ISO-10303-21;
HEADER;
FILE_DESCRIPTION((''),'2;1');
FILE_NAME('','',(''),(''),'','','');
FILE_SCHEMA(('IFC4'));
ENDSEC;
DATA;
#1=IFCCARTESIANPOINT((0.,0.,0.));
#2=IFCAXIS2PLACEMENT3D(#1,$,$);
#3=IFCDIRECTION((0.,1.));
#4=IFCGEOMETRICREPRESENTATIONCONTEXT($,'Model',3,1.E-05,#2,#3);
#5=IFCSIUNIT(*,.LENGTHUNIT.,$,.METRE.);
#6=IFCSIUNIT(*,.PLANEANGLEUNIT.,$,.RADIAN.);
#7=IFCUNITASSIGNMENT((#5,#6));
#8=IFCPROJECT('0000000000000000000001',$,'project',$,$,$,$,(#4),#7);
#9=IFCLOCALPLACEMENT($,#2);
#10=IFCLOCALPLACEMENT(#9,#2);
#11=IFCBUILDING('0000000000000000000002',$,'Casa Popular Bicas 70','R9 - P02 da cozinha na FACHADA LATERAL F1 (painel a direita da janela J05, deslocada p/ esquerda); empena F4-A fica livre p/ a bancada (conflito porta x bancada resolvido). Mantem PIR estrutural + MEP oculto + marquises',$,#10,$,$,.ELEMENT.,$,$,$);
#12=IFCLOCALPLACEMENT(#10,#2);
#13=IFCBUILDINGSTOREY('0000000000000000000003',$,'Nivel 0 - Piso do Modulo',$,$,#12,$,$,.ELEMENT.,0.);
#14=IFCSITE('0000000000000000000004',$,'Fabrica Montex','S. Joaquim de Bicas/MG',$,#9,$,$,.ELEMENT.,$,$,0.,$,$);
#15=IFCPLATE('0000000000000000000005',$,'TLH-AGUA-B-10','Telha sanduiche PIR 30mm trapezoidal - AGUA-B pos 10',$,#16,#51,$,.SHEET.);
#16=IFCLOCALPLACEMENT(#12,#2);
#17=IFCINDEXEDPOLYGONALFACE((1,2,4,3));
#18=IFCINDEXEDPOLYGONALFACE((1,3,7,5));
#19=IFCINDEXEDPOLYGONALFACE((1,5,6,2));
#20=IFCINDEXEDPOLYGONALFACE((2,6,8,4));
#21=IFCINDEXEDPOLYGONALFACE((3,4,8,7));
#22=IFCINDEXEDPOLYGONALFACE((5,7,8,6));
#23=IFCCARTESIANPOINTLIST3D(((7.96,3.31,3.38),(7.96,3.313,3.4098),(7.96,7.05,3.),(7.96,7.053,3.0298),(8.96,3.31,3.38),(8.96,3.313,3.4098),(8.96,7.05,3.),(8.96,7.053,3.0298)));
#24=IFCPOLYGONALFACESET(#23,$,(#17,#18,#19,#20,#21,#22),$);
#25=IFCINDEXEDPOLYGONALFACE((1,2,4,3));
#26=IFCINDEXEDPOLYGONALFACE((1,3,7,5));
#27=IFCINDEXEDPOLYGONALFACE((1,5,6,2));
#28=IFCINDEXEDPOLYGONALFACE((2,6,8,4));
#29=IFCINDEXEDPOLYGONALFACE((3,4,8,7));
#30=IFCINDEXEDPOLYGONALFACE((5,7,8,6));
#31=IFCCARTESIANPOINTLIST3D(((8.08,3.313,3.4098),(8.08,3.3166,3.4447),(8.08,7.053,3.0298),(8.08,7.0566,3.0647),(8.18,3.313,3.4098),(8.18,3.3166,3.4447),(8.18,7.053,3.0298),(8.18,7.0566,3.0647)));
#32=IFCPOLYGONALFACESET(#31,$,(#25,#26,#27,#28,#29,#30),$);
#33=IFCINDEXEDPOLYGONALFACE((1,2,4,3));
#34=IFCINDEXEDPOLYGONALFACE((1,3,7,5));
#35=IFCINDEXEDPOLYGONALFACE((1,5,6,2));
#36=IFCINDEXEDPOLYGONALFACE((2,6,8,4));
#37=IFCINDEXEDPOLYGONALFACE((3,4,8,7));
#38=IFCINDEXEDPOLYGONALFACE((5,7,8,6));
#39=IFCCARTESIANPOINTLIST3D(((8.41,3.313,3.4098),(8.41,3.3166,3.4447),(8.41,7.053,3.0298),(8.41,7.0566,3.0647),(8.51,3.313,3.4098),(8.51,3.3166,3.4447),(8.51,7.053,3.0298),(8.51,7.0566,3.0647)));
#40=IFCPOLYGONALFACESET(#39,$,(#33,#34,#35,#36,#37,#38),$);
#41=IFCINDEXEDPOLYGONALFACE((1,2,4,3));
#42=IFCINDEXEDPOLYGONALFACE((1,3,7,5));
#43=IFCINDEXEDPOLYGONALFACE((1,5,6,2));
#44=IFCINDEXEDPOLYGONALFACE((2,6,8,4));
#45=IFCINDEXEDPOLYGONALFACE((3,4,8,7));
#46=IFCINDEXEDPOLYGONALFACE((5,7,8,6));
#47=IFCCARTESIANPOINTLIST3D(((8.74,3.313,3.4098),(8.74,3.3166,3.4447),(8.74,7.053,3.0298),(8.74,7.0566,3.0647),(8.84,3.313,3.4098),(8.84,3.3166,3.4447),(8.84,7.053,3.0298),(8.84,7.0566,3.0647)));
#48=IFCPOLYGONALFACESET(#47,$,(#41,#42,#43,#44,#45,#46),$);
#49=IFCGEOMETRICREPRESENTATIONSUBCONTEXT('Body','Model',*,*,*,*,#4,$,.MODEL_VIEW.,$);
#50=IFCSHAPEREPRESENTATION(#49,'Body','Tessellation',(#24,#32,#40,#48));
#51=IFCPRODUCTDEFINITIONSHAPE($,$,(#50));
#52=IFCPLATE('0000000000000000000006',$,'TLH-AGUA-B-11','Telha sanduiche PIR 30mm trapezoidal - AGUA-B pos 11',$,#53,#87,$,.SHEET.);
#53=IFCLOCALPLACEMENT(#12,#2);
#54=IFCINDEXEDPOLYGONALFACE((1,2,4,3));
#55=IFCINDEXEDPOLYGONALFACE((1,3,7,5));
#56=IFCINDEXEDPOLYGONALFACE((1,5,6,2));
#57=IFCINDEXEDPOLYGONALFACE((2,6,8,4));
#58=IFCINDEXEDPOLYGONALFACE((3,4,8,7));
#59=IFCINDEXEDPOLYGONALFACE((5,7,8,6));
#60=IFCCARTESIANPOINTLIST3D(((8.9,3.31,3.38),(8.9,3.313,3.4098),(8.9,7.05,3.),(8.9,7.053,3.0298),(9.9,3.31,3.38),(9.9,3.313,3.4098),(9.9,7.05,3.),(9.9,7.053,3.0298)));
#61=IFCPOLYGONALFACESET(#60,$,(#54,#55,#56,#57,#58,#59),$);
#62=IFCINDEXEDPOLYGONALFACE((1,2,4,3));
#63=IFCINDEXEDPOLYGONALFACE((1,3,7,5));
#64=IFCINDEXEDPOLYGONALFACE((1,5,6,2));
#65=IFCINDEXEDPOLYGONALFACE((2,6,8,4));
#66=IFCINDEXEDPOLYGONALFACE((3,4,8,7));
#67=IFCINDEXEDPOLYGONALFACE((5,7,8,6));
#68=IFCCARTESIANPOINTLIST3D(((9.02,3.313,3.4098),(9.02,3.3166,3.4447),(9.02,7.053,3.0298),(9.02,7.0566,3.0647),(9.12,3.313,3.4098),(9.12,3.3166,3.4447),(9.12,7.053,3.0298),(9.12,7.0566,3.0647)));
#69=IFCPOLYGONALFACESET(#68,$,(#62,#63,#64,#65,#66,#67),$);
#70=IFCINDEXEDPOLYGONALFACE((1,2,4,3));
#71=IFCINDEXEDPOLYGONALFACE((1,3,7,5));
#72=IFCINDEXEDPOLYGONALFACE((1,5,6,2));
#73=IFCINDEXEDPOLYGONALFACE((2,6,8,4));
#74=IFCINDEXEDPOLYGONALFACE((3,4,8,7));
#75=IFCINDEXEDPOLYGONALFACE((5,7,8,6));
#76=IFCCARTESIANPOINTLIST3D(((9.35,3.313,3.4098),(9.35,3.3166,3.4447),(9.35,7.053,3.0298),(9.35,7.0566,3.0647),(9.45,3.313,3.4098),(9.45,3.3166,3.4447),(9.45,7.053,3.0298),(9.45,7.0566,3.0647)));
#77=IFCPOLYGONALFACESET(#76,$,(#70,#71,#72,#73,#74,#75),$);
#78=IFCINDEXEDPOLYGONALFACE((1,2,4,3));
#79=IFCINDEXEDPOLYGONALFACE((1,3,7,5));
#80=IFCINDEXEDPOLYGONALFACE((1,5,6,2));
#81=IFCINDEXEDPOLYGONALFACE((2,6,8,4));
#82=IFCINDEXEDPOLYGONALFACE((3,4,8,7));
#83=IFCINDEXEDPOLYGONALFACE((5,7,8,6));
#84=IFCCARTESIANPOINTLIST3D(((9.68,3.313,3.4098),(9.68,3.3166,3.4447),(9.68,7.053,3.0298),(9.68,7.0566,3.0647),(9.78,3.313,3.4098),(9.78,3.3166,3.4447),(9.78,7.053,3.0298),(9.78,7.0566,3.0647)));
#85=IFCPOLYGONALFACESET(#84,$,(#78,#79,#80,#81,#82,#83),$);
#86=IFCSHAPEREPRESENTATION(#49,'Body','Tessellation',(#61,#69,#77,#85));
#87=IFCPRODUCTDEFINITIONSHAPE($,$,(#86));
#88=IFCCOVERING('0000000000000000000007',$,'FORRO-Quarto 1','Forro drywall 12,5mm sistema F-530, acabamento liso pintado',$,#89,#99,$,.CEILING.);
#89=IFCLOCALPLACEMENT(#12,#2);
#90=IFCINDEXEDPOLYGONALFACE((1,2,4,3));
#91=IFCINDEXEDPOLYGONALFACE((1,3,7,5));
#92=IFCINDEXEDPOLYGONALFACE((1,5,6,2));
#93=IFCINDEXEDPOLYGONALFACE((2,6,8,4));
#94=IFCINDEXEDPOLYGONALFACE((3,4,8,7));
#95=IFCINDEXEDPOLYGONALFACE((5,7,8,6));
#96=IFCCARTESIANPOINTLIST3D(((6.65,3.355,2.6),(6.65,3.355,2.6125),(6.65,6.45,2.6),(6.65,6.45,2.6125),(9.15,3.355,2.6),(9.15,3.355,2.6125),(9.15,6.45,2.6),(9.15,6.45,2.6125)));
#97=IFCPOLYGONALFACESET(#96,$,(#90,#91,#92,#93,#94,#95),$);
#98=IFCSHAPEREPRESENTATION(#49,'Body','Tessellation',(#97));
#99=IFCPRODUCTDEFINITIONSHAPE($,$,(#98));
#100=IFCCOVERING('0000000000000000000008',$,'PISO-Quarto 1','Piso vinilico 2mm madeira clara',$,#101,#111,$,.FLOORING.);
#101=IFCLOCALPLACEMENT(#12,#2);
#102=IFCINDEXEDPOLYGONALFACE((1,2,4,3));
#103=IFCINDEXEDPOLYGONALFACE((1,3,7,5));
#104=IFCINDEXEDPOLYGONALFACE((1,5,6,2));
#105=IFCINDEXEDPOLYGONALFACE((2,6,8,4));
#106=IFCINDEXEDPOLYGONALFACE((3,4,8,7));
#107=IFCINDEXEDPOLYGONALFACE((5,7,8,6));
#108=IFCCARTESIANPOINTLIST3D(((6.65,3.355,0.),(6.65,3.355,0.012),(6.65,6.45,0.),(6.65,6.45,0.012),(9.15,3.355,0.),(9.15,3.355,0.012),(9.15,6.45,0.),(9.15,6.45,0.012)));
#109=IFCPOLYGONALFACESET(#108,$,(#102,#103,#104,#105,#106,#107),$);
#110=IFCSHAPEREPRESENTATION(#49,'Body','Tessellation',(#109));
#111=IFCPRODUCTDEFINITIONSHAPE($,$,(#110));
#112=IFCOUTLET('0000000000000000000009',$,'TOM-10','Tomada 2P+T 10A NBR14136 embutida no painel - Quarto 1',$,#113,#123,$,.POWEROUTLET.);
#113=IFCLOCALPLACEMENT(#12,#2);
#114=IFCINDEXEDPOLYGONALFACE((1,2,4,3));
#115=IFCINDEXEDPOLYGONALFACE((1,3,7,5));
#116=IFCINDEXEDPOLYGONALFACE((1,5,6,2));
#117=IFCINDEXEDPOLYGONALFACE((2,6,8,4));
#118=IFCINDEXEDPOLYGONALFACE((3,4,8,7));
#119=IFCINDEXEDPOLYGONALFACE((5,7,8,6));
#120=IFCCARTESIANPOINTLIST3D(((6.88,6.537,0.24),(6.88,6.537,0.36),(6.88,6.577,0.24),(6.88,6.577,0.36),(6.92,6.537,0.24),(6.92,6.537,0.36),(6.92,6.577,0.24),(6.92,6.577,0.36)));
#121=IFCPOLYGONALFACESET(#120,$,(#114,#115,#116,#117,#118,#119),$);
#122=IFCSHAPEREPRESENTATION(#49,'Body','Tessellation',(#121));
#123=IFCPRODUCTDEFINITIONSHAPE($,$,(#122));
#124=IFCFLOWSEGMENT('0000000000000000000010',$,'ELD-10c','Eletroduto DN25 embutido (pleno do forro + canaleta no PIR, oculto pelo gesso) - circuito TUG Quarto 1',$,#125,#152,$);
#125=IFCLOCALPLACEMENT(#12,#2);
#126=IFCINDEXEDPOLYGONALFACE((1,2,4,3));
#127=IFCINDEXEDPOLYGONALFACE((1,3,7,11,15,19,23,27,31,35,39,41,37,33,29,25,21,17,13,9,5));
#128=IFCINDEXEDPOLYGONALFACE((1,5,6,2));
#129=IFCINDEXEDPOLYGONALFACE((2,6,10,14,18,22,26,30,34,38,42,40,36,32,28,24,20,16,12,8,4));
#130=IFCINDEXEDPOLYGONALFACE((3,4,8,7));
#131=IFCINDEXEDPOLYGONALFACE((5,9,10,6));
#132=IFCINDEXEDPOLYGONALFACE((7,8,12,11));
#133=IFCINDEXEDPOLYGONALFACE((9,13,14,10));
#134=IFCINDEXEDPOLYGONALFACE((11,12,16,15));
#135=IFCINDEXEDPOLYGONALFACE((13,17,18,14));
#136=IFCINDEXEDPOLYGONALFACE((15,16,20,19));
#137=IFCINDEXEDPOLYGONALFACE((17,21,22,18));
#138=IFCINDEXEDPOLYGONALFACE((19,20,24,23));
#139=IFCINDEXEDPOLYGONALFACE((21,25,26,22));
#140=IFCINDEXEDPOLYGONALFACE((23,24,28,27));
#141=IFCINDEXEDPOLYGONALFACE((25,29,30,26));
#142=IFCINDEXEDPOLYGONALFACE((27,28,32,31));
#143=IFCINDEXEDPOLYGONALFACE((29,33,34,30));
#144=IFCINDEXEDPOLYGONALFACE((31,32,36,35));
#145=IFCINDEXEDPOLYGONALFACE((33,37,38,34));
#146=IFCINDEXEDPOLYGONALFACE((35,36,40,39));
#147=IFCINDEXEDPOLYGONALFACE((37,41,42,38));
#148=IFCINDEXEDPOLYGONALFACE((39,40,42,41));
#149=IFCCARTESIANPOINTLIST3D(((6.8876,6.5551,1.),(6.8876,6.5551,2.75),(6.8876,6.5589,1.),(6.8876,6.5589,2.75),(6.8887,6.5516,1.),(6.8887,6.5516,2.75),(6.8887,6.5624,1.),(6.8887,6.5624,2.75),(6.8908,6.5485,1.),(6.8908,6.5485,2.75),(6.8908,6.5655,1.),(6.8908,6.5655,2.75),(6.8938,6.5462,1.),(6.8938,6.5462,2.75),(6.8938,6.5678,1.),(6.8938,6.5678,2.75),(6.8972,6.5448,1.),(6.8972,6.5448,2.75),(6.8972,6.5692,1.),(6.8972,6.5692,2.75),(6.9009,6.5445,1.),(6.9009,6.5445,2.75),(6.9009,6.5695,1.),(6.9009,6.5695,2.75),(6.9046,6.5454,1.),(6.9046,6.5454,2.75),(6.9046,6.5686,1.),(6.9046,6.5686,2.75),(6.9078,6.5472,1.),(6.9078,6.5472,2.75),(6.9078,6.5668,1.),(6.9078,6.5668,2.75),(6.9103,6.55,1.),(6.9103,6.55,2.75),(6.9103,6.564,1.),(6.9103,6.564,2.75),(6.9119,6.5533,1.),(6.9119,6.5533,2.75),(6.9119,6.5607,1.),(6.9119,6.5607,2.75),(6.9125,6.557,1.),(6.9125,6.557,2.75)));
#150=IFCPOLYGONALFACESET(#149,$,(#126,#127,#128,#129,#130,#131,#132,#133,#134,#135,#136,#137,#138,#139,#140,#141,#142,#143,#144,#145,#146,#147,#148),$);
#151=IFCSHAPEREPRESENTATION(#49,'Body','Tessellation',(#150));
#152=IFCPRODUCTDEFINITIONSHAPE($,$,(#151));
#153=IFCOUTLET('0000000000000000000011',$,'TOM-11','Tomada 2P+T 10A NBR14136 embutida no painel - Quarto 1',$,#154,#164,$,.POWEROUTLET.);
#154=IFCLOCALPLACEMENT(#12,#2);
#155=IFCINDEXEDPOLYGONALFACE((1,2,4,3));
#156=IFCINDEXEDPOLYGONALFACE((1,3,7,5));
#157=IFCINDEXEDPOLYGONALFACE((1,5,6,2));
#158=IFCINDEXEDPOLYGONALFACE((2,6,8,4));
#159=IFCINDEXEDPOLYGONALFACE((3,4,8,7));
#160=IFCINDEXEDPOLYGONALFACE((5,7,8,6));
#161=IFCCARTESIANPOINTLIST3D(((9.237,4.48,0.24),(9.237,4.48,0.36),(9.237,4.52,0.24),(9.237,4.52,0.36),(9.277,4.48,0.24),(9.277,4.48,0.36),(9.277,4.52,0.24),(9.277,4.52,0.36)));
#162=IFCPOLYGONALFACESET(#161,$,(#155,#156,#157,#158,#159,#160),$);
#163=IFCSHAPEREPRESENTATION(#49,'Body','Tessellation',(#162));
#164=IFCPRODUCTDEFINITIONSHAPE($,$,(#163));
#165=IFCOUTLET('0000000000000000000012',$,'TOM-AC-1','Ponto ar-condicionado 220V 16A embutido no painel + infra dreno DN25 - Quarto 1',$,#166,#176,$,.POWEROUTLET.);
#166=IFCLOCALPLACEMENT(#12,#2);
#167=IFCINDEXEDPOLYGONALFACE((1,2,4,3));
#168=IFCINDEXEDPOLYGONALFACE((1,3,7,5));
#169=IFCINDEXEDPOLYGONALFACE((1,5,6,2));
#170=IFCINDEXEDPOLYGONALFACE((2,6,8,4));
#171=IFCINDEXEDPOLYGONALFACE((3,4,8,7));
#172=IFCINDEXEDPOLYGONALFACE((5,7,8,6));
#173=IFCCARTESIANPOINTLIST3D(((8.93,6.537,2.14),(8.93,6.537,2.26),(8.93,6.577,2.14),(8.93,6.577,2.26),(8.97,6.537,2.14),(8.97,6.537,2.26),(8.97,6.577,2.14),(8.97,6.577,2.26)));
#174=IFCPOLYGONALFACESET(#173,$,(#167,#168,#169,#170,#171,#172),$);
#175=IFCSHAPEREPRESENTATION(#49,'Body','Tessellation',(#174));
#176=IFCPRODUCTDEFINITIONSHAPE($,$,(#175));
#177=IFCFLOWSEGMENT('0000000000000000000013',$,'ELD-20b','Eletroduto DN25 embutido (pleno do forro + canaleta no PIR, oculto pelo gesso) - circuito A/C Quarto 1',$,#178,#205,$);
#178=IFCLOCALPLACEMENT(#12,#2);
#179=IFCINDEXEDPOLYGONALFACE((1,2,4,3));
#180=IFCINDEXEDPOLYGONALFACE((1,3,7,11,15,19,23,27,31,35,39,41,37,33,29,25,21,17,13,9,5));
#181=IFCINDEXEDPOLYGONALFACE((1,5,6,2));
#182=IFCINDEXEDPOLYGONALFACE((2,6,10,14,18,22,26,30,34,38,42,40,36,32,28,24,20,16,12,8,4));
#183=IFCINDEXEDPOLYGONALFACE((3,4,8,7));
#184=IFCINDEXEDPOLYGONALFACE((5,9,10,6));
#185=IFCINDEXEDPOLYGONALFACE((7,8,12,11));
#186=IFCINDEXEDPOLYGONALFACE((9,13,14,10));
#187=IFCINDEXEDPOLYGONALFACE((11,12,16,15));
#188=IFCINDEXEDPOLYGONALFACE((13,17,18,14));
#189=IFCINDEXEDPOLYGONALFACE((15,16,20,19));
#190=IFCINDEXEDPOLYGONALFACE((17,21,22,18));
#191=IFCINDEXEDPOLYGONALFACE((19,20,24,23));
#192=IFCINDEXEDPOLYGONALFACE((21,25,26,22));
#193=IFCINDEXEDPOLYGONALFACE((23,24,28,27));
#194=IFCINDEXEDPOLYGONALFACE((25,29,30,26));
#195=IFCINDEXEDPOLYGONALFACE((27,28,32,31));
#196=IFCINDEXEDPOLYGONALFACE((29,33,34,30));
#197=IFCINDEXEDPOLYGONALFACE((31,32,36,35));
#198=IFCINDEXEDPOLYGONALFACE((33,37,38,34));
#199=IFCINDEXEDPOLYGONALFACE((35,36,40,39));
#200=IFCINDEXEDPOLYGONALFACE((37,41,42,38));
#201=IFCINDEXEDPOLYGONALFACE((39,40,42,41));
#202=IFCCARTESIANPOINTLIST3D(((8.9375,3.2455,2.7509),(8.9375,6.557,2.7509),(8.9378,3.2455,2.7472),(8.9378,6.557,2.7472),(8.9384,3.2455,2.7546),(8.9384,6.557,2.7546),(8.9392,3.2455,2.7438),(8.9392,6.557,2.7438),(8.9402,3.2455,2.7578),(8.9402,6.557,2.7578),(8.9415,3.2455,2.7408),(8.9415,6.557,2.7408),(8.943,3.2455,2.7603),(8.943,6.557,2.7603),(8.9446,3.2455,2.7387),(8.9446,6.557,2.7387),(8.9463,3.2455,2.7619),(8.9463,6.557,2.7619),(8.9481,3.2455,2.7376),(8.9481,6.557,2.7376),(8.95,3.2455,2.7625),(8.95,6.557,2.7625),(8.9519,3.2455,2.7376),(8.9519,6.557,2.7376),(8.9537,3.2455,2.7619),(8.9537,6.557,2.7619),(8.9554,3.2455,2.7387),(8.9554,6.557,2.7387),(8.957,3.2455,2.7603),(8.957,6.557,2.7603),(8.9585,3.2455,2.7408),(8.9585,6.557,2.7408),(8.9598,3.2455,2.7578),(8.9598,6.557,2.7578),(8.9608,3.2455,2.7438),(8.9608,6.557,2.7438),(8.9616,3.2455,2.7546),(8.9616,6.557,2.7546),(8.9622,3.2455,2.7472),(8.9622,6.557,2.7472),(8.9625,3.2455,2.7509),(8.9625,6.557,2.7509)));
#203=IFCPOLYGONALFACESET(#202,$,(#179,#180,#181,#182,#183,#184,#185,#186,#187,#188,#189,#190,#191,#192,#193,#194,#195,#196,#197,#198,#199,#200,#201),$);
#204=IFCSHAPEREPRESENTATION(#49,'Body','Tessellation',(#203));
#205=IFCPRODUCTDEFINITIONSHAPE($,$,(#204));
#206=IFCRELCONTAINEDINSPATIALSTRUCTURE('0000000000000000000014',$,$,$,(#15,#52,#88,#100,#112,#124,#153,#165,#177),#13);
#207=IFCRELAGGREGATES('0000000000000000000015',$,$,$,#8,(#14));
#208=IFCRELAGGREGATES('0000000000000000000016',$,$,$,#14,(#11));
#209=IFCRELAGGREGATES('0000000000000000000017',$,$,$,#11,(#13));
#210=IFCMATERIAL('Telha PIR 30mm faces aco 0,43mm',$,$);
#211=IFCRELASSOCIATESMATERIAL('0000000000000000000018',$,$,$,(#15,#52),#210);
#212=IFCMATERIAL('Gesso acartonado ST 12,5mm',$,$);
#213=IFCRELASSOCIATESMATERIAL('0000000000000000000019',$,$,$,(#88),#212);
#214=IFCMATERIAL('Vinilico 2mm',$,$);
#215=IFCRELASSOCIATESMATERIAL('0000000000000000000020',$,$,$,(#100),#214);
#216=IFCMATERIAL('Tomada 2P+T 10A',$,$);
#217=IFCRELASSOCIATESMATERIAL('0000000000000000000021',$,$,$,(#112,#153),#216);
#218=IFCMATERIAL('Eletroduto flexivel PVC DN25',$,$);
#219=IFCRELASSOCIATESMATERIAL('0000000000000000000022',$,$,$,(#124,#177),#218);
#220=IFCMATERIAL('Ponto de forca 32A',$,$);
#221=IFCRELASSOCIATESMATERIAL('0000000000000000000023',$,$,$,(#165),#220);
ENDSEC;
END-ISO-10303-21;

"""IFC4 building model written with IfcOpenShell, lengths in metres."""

from ifc_helpers import new_model, si_unit, direction, frame, frame_2d, origin, origin_2d, place, context, subcontext, project, spatial, rectangle, circle, extrude, material, element, save


model = new_model("IFC4")

# Units and contexts
model_context_1 = context("Model", 3, precision=1e-05, world=origin(), true_north=direction((0.0, 1.0)))
body_context_1 = subcontext(model_context_1, "Body", "Model", "MODEL_VIEW")
ifc_project = project(units=[si_unit("LENGTHUNIT", "METRE"), si_unit("PLANEANGLEUNIT", "RADIAN")], contexts=[model_context_1])

# Site, building, storey
site_placement = place(None, origin())
site = spatial("IfcSite", under=ifc_project, at=site_placement, Name="Fabrica Montex", Description="S. Joaquim de Bicas/MG", CompositionType="ELEMENT", RefElevation=0.0)
building_placement = place(site_placement, origin())
building = spatial("IfcBuilding", under=site, at=building_placement, Name="Casa Popular Bicas 70", Description="R9 - P02 da cozinha na FACHADA LATERAL F1 (painel a direita da janela J05, deslocada p/ esquerda); empena F4-A fica livre p/ a bancada (conflito porta x bancada resolvido). Mantem PIR estrutural + MEP oculto + marquises", CompositionType="ELEMENT")
storey_placement = place(building_placement, origin())
storey = spatial("IfcBuildingStorey", under=building, at=storey_placement, Name="Nivel 0 - Piso do Modulo", CompositionType="ELEMENT", Elevation=0.0)

# Plates
ifc_material_1 = material(Name="Telha PIR 30mm faces aco 0,43mm")
for number, where, z_axis, x_axis, name, description in (
    (1, (7.96, 3.31, 3.38), (0.0, 0.101084, 0.994878), (1.0, 0.0, 0.0), "TLH-AGUA-B-10", "Telha sanduiche PIR 30mm trapezoidal - AGUA-B pos 10"),
    (2, (8.9, 3.31, 3.38), (0.0, 0.101084, 0.994878), (1.0, 0.0, 0.0), "TLH-AGUA-B-11", "Telha sanduiche PIR 30mm trapezoidal - AGUA-B pos 11"),
):
    element("IfcPlate", number, at=place(storey_placement, frame(where, z_axis=z_axis, x_axis=x_axis)), inside=storey, material=ifc_material_1, Name=name, Description=description, PredefinedType="SHEET", context=body_context_1, shape_type="SweptSolid", body=[
        extrude(rectangle(XDim=1.0, YDim=3.7593, at=frame_2d((0.5, 1.8796))), origin(), (0.0, 0.0, 1.0), 0.03),
        extrude(rectangle(XDim=0.1, YDim=3.7593, at=frame_2d((0.17, 1.8796))), frame((0.0, 0.0, 0.03)), (0.0, 0.0, 1.0), 0.035),
        extrude(rectangle(XDim=0.1, YDim=3.7593, at=frame_2d((0.5, 1.8796))), frame((0.0, 0.0, 0.03)), (0.0, 0.0, 1.0), 0.035),
        extrude(rectangle(XDim=0.1, YDim=3.7593, at=frame_2d((0.83, 1.8796))), frame((0.0, 0.0, 0.03)), (0.0, 0.0, 1.0), 0.035),
    ])

# Coverings
ifc_material_2 = material(Name="Gesso acartonado ST 12,5mm")
covering_1_placement = place(storey_placement, frame((6.65, 3.355, 2.6)))
element("IfcCovering", 3, at=covering_1_placement, inside=storey, material=ifc_material_2, Name="FORRO-Quarto 1", Description="Forro drywall 12,5mm sistema F-530, acabamento liso pintado", PredefinedType="CEILING", context=body_context_1, shape_type="SweptSolid", body=[
    extrude(rectangle(XDim=2.5, YDim=3.095, at=frame_2d((1.25, 1.5475))), origin(), (0.0, 0.0, 1.0), 0.0125),
])
ifc_material_3 = material(Name="Vinilico 2mm")
covering_2_placement = place(storey_placement, frame((6.65, 3.355, 0.0)))
element("IfcCovering", 4, at=covering_2_placement, inside=storey, material=ifc_material_3, Name="PISO-Quarto 1", Description="Piso vinilico 2mm madeira clara", PredefinedType="FLOORING", context=body_context_1, shape_type="SweptSolid", body=[
    extrude(rectangle(XDim=2.5, YDim=3.095, at=frame_2d((1.25, 1.5475))), origin(), (0.0, 0.0, 1.0), 0.012),
])

# Outlet
ifc_material_4 = material(Name="Tomada 2P+T 10A")
outlet_1_placement = place(storey_placement, frame((6.88, 6.537, 0.24)))
element("IfcOutlet", 5, at=outlet_1_placement, inside=storey, material=ifc_material_4, Name="TOM-10", Description="Tomada 2P+T 10A NBR14136 embutida no painel - Quarto 1", PredefinedType="POWEROUTLET", context=body_context_1, shape_type="SweptSolid", body=[
    extrude(rectangle(XDim=0.04, YDim=0.04, at=frame_2d((0.02, 0.02))), origin(), (0.0, 0.0, 1.0), 0.12),
])

# Flow segment
ifc_material_5 = material(Name="Eletroduto flexivel PVC DN25")
flow_segment_1_placement = place(storey_placement, frame((6.9, 6.557, 2.75), z_axis=(0.0, 0.0, -1.0), x_axis=(1.0, 0.0, 0.0)))
element("IfcFlowSegment", 6, at=flow_segment_1_placement, inside=storey, material=ifc_material_5, Name="ELD-10c", Description="Eletroduto DN25 embutido (pleno do forro + canaleta no PIR, oculto pelo gesso) - circuito TUG Quarto 1", context=body_context_1, shape_type="SweptSolid", body=[
    extrude(circle(Radius=0.0125, at=origin_2d()), origin(), (0.0, 0.0, 1.0), 1.75),
])

# Outlets
outlet_2_placement = place(storey_placement, frame((9.237, 4.48, 0.24)))
element("IfcOutlet", 7, at=outlet_2_placement, inside=storey, material=ifc_material_4, Name="TOM-11", Description="Tomada 2P+T 10A NBR14136 embutida no painel - Quarto 1", PredefinedType="POWEROUTLET", context=body_context_1, shape_type="SweptSolid", body=[
    extrude(rectangle(XDim=0.04, YDim=0.04, at=frame_2d((0.02, 0.02))), origin(), (0.0, 0.0, 1.0), 0.12),
])
ifc_material_6 = material(Name="Ponto de forca 32A")
outlet_3_placement = place(storey_placement, frame((8.93, 6.537, 2.14)))
element("IfcOutlet", 8, at=outlet_3_placement, inside=storey, material=ifc_material_6, Name="TOM-AC-1", Description="Ponto ar-condicionado 220V 16A embutido no painel + infra dreno DN25 - Quarto 1", PredefinedType="POWEROUTLET", context=body_context_1, shape_type="SweptSolid", body=[
    extrude(rectangle(XDim=0.04, YDim=0.04, at=frame_2d((0.02, 0.02))), origin(), (0.0, 0.0, 1.0), 0.12),
])

# Flow segment
flow_segment_2_placement = place(storey_placement, frame((8.95, 3.2455, 2.75), z_axis=(0.0, 1.0, 0.0), x_axis=(0.0, 0.0, 1.0)))
element("IfcFlowSegment", 9, at=flow_segment_2_placement, inside=storey, material=ifc_material_5, Name="ELD-20b", Description="Eletroduto DN25 embutido (pleno do forro + canaleta no PIR, oculto pelo gesso) - circuito A/C Quarto 1", context=body_context_1, shape_type="SweptSolid", body=[
    extrude(circle(Radius=0.0125, at=origin_2d()), origin(), (0.0, 0.0, 1.0), 3.3115),
])

save(model, "model.ifc")
